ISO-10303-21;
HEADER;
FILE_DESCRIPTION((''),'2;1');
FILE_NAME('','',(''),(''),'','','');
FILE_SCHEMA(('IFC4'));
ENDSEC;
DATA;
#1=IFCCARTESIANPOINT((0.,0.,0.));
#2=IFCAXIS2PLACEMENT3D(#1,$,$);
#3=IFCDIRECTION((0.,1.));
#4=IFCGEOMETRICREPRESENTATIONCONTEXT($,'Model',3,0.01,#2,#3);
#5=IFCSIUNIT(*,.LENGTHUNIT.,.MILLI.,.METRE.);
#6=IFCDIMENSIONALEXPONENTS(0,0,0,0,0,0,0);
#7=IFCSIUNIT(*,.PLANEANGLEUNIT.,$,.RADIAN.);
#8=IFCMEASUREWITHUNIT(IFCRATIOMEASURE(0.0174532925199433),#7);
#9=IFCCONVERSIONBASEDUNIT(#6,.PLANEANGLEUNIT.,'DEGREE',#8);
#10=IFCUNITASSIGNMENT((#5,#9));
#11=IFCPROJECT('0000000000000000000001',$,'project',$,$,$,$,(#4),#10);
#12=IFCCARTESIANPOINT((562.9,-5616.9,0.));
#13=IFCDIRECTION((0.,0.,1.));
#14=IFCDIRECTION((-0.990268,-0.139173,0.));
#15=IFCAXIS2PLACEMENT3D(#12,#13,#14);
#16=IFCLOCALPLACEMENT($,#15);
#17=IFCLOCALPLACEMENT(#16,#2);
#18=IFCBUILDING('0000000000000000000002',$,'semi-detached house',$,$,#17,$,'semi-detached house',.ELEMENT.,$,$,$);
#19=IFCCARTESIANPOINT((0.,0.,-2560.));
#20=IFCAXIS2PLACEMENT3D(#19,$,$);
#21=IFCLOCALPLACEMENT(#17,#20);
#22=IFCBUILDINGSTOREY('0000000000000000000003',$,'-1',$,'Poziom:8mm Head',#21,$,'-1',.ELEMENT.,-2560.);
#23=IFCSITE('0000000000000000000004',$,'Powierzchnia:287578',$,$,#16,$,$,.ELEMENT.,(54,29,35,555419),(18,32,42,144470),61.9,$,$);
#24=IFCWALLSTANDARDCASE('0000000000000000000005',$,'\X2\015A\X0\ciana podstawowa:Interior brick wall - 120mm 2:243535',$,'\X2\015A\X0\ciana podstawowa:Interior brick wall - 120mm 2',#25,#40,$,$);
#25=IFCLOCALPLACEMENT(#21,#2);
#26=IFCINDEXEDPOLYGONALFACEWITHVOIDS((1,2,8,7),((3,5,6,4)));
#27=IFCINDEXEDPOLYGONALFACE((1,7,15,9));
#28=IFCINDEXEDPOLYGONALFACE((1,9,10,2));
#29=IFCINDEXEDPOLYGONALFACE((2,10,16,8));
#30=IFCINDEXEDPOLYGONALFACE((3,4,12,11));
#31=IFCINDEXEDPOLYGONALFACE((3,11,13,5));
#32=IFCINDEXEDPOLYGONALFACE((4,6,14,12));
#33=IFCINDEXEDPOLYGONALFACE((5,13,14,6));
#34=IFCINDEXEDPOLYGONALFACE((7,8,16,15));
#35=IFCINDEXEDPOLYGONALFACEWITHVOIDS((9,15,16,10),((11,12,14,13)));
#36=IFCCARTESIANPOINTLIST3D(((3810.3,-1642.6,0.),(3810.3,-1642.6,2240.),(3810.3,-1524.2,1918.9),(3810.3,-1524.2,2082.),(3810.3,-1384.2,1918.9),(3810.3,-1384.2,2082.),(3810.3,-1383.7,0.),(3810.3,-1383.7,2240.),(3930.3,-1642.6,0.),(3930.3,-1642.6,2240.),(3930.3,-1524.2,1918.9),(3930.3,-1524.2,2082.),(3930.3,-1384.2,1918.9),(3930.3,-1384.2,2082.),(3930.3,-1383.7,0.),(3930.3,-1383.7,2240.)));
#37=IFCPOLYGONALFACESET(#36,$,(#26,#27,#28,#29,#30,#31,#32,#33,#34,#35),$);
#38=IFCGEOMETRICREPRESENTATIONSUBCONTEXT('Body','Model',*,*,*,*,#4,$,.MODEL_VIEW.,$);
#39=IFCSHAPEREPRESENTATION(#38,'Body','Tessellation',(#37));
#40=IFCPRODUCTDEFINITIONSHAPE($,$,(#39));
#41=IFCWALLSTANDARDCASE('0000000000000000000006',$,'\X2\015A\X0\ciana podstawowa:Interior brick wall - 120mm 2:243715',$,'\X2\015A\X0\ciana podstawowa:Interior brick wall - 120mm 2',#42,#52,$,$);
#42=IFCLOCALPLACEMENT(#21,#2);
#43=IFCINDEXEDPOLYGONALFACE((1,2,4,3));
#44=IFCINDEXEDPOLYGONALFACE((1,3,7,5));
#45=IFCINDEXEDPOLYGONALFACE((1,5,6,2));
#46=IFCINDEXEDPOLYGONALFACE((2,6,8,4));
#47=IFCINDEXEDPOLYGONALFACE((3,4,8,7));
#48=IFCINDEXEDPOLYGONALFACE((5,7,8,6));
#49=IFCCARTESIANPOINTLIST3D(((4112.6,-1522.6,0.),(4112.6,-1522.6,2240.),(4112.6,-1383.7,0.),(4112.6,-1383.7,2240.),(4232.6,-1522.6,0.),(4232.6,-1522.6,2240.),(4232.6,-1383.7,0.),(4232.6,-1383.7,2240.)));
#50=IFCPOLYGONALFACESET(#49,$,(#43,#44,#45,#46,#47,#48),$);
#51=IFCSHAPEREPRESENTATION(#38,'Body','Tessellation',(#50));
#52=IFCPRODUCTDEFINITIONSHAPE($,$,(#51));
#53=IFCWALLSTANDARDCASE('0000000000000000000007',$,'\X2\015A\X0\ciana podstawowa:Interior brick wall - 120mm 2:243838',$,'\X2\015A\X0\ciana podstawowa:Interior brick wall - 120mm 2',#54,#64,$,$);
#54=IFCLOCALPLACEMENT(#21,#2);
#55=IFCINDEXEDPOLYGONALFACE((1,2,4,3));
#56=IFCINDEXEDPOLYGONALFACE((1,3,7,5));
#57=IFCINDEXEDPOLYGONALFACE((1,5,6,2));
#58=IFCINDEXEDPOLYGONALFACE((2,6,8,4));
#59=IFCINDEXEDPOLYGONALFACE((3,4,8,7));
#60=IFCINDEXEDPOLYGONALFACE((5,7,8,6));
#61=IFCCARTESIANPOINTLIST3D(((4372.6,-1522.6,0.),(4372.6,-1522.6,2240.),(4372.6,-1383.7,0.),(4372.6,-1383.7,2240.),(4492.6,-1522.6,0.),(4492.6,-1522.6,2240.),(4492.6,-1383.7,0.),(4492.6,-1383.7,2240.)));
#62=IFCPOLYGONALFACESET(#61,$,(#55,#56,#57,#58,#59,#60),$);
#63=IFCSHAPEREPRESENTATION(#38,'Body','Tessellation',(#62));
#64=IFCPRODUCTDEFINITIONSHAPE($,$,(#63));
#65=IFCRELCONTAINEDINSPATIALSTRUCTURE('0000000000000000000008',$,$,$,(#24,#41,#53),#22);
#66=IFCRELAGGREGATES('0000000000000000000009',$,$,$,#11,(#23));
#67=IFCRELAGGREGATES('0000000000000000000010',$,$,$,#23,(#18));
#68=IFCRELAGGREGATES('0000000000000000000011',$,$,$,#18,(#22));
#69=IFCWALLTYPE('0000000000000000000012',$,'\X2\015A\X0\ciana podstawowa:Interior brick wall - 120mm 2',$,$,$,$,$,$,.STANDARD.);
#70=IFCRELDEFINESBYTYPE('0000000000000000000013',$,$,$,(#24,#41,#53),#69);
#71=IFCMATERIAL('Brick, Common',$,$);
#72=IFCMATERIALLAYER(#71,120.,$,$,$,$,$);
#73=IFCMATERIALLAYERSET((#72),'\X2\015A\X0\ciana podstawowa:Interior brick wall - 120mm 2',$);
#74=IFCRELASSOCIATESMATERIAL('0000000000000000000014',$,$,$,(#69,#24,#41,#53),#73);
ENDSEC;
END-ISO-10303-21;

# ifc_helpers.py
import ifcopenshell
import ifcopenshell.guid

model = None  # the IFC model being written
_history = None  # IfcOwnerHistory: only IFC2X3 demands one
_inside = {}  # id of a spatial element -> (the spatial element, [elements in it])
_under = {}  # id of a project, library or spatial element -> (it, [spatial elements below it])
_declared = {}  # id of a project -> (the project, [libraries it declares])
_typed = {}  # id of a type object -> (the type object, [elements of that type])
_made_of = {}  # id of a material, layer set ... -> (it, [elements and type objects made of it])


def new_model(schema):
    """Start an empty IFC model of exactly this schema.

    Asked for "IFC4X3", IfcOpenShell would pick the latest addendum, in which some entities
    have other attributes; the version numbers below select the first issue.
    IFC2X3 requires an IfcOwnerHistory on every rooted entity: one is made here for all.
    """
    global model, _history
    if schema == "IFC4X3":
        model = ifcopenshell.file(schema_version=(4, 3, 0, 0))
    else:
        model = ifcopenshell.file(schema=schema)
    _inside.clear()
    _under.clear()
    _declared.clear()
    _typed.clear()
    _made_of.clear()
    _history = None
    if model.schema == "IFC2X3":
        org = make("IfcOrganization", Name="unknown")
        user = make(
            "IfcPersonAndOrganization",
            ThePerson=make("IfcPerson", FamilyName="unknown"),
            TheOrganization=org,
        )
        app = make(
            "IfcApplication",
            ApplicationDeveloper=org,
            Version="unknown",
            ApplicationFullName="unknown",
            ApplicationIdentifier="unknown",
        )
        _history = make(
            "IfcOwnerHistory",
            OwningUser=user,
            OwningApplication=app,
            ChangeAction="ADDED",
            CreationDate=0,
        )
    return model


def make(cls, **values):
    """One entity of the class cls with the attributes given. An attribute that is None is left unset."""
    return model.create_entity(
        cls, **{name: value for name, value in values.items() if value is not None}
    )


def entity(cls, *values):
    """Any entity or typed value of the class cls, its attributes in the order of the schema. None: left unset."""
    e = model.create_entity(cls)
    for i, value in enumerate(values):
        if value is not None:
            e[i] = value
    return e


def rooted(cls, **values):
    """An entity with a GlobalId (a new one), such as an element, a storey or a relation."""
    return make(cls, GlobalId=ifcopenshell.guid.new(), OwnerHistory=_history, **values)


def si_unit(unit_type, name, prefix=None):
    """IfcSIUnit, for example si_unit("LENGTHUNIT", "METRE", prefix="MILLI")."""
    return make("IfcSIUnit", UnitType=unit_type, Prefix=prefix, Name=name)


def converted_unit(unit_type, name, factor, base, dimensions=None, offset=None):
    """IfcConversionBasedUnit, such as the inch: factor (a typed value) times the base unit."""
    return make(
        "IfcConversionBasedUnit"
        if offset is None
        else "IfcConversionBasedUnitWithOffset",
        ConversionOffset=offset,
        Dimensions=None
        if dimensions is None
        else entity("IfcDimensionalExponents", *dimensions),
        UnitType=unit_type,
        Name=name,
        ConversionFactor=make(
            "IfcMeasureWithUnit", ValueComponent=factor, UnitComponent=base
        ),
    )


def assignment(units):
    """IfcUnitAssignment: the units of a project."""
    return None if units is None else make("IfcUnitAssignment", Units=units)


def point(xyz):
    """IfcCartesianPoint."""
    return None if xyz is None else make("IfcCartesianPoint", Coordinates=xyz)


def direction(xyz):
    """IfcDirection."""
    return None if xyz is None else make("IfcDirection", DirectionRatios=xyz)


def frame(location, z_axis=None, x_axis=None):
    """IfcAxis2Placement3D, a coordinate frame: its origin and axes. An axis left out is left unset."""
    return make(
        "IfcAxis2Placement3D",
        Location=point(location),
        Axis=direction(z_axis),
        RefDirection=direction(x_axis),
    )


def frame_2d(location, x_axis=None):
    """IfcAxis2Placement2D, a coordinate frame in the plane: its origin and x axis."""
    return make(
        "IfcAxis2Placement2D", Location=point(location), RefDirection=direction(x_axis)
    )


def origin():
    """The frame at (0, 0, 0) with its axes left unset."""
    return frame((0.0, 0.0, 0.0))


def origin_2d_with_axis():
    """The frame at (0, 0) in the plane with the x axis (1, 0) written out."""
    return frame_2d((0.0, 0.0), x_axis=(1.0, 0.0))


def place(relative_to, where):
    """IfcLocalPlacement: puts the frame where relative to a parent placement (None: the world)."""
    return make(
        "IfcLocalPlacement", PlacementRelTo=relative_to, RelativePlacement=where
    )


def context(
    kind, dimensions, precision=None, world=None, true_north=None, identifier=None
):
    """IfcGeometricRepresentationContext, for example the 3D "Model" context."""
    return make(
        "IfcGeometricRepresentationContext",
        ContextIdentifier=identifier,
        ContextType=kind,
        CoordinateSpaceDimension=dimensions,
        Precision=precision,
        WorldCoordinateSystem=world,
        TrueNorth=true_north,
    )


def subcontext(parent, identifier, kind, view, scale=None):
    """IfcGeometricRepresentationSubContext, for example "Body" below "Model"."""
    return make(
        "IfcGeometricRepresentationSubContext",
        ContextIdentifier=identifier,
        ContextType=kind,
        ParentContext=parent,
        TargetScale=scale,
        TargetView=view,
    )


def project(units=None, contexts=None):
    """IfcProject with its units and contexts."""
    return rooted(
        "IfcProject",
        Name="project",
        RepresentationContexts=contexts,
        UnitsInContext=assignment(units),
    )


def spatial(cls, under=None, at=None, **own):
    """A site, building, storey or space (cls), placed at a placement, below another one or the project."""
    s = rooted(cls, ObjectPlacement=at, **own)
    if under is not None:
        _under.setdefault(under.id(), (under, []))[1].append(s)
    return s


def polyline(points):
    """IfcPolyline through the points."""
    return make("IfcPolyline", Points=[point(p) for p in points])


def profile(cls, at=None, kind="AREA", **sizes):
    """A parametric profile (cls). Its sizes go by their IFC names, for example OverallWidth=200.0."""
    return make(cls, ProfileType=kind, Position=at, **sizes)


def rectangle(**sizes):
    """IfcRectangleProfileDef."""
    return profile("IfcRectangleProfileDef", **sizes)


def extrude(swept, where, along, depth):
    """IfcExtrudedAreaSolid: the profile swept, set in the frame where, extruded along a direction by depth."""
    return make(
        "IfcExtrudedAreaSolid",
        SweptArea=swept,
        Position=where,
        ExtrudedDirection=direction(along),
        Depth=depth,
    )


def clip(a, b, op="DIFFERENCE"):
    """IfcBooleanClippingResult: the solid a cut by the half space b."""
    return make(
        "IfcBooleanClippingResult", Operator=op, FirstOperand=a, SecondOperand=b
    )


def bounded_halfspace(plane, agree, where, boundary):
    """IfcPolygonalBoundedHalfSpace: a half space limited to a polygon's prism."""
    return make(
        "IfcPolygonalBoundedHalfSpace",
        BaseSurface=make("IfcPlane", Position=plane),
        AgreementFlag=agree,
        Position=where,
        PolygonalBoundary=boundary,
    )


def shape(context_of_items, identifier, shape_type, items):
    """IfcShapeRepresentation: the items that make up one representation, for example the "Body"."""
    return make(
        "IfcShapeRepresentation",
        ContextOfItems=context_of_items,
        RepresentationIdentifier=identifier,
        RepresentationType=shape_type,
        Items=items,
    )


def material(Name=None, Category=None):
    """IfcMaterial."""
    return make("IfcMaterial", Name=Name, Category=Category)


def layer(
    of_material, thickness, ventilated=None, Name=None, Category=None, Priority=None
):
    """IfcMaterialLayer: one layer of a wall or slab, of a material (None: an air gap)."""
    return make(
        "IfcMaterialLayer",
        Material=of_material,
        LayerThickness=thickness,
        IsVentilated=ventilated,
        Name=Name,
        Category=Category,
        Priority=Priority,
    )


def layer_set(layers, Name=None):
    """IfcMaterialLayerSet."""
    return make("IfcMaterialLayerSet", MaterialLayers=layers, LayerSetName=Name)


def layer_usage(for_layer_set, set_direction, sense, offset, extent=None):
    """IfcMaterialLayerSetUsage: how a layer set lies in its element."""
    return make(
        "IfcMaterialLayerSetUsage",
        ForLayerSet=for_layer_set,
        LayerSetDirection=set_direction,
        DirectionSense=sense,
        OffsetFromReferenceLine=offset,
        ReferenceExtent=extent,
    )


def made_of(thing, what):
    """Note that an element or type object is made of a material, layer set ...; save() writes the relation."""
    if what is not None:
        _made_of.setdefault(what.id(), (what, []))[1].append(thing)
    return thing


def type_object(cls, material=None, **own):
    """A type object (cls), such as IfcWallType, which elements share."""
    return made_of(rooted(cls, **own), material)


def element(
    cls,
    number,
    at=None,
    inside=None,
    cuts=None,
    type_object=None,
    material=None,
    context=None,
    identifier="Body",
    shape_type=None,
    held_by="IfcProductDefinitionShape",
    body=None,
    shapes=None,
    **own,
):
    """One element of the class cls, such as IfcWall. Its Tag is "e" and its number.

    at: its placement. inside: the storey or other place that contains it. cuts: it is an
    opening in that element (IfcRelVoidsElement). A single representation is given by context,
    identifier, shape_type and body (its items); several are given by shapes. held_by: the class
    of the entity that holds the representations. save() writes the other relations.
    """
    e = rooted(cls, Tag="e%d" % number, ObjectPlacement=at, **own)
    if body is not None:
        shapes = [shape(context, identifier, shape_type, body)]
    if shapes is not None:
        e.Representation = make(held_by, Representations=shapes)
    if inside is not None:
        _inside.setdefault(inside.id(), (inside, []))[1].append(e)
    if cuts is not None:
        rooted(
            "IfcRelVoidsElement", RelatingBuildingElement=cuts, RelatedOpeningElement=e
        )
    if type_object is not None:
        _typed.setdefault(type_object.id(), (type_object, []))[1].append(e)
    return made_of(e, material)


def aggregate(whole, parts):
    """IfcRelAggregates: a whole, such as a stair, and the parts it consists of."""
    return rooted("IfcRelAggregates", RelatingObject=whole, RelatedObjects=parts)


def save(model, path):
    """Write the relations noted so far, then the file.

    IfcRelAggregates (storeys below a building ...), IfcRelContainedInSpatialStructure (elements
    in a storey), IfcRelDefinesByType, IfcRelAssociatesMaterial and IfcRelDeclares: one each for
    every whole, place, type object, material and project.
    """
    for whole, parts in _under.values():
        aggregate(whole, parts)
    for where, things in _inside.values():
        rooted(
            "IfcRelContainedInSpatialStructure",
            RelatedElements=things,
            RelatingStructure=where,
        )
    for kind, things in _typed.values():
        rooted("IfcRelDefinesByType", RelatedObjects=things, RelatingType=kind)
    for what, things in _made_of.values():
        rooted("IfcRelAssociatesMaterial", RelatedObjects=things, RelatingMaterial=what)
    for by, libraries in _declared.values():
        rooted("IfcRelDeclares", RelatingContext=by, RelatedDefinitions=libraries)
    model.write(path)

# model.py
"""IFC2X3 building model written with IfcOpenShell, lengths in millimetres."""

from ifc_helpers import new_model, entity, si_unit, converted_unit, direction, frame, frame_2d, origin, origin_2d_with_axis, place, context, subcontext, project, spatial, polyline, rectangle, extrude, clip, bounded_halfspace, material, layer, layer_set, layer_usage, type_object, element, save


model = new_model("IFC2X3")

# Units and contexts
model_context = context("Model", 3, precision=0.01, world=origin(), true_north=direction((0.0, 1.0)))
body_context = subcontext(model_context, "Body", "Model", "MODEL_VIEW")
ifc_project = project(units=[si_unit("LENGTHUNIT", "METRE", prefix="MILLI"), converted_unit("PLANEANGLEUNIT", "DEGREE", entity("IfcRatioMeasure", 0.0174532925199433), si_unit("PLANEANGLEUNIT", "RADIAN"), dimensions=[0, 0, 0, 0, 0, 0, 0])], contexts=[model_context])

# Site, building, storey
site_placement = place(None, frame((562.9, -5616.9, 0.0), z_axis=(0.0, 0.0, 1.0), x_axis=(-0.990268, -0.139173, 0.0)))
site = spatial("IfcSite", under=ifc_project, at=site_placement, Name="Powierzchnia:287578", CompositionType="ELEMENT", RefLatitude=(54, 29, 35, 555419), RefLongitude=(18, 32, 42, 144470), RefElevation=61.9)
building_placement = place(site_placement, origin())
building = spatial("IfcBuilding", under=site, at=building_placement, Name="semi-detached house", LongName="semi-detached house", CompositionType="ELEMENT")
storey_placement = place(building_placement, frame((0.0, 0.0, -2560.0)))
storey = spatial("IfcBuildingStorey", under=building, at=storey_placement, Name="-1", ObjectType="Poziom:8mm Head", LongName="-1", CompositionType="ELEMENT", Elevation=-2560.0)

# Shared definitions
ifc_material_1 = material(Name="Brick, Common")

# Shared definitions
ifc_layer_1 = layer(ifc_material_1, 120.0)
ifc_layer_set_1 = layer_set([ifc_layer_1], Name="Ściana podstawowa:Interior brick wall - 120mm 2")
wall_type_1 = type_object("IfcWallType", Name="Ściana podstawowa:Interior brick wall - 120mm 2", PredefinedType="STANDARD", material=ifc_layer_set_1)

# Wall, opening
ifc_layer_usage_1 = layer_usage(ifc_layer_set_1, "AXIS2", "POSITIVE", -60.0)
wall_1_placement = place(storey_placement, frame((3870.3, -1383.7, 0.0), z_axis=(0.0, 0.0, 1.0), x_axis=(0.0, -1.0, 0.0)))
wall_1 = element("IfcWallStandardCase", 1, at=wall_1_placement, inside=storey, type_object=wall_type_1, material=ifc_layer_usage_1, Name="Ściana podstawowa:Interior brick wall - 120mm 2:243535", ObjectType="Ściana podstawowa:Interior brick wall - 120mm 2", context=body_context, shape_type="Clipping", body=[
    clip(extrude(rectangle(XDim=258.9, YDim=120.0, at=frame_2d((129.5, 0.0), x_axis=(-1.0, 0.0))), origin(), (0.0, 0.0, 1.0), 2240.0), bounded_halfspace(frame((258.9, -60.0, 0.0), z_axis=(0.0, 0.0, 1.0), x_axis=(-1.0, 0.0, 0.0)), True, frame((258.9, -60.0, 0.0), z_axis=(0.0, 0.0, 1.0), x_axis=(-1.0, 0.0, 0.0)), polyline([(0.0, 0.0), (0.0, -120.0), (258.9, -120.0), (258.9, -50.5), (258.9, 0.0), (0.0, 0.0)]))),
])
opening_1_placement = place(wall_1_placement, origin())
element("IfcOpeningElement", 2, at=opening_1_placement, cuts=wall_1, ObjectType="Opening", context=body_context, shape_type="SweptSolid", body=[
    extrude(rectangle(XDim=163.1, YDim=140.0, at=origin_2d_with_axis()), frame((70.5, -60.0, 2000.5), z_axis=(0.0, 1.0, 0.0), x_axis=(0.0, 0.0, -1.0)), (0.0, 0.0, 1.0), 120.0),
])

# Walls
ifc_layer_usage_2 = layer_usage(ifc_layer_set_1, "AXIS2", "NEGATIVE", 60.0)
wall_2_placement = place(storey_placement, frame((4172.6, -1522.6, 0.0), z_axis=(0.0, 0.0, 1.0), x_axis=(0.0, 1.0, 0.0)))
element("IfcWallStandardCase", 3, at=wall_2_placement, inside=storey, type_object=wall_type_1, material=ifc_layer_usage_2, Name="Ściana podstawowa:Interior brick wall - 120mm 2:243715", ObjectType="Ściana podstawowa:Interior brick wall - 120mm 2", context=body_context, shape_type="Clipping", body=[
    clip(extrude(rectangle(XDim=138.9, YDim=120.0, at=frame_2d((69.5, 0.0), x_axis=(-1.0, 0.0))), origin(), (0.0, 0.0, 1.0), 2240.0), bounded_halfspace(frame((138.9, -60.0, 0.0)), True, frame((138.9, -60.0, 0.0)), polyline([(0.0, 0.0), (0.0, 120.0), (-138.9, 120.0), (-138.9, 0.0), (0.0, 0.0)]))),
])
ifc_layer_usage_3 = layer_usage(ifc_layer_set_1, "AXIS2", "NEGATIVE", 60.0)
wall_3_placement = place(storey_placement, frame((4432.6, -1522.6, 0.0), z_axis=(0.0, 0.0, 1.0), x_axis=(0.0, 1.0, 0.0)))
element("IfcWallStandardCase", 4, at=wall_3_placement, inside=storey, type_object=wall_type_1, material=ifc_layer_usage_3, Name="Ściana podstawowa:Interior brick wall - 120mm 2:243838", ObjectType="Ściana podstawowa:Interior brick wall - 120mm 2", context=body_context, shape_type="Clipping", body=[
    clip(extrude(rectangle(XDim=138.9, YDim=120.0, at=frame_2d((69.5, 0.0), x_axis=(-1.0, 0.0))), origin(), (0.0, 0.0, 1.0), 2240.0), bounded_halfspace(frame((138.9, -60.0, 0.0)), True, frame((138.9, -60.0, 0.0)), polyline([(0.0, 0.0), (0.0, 120.0), (-138.9, 120.0), (-138.9, 0.0), (0.0, 0.0)]))),
])

save(model, "model.ifc")
